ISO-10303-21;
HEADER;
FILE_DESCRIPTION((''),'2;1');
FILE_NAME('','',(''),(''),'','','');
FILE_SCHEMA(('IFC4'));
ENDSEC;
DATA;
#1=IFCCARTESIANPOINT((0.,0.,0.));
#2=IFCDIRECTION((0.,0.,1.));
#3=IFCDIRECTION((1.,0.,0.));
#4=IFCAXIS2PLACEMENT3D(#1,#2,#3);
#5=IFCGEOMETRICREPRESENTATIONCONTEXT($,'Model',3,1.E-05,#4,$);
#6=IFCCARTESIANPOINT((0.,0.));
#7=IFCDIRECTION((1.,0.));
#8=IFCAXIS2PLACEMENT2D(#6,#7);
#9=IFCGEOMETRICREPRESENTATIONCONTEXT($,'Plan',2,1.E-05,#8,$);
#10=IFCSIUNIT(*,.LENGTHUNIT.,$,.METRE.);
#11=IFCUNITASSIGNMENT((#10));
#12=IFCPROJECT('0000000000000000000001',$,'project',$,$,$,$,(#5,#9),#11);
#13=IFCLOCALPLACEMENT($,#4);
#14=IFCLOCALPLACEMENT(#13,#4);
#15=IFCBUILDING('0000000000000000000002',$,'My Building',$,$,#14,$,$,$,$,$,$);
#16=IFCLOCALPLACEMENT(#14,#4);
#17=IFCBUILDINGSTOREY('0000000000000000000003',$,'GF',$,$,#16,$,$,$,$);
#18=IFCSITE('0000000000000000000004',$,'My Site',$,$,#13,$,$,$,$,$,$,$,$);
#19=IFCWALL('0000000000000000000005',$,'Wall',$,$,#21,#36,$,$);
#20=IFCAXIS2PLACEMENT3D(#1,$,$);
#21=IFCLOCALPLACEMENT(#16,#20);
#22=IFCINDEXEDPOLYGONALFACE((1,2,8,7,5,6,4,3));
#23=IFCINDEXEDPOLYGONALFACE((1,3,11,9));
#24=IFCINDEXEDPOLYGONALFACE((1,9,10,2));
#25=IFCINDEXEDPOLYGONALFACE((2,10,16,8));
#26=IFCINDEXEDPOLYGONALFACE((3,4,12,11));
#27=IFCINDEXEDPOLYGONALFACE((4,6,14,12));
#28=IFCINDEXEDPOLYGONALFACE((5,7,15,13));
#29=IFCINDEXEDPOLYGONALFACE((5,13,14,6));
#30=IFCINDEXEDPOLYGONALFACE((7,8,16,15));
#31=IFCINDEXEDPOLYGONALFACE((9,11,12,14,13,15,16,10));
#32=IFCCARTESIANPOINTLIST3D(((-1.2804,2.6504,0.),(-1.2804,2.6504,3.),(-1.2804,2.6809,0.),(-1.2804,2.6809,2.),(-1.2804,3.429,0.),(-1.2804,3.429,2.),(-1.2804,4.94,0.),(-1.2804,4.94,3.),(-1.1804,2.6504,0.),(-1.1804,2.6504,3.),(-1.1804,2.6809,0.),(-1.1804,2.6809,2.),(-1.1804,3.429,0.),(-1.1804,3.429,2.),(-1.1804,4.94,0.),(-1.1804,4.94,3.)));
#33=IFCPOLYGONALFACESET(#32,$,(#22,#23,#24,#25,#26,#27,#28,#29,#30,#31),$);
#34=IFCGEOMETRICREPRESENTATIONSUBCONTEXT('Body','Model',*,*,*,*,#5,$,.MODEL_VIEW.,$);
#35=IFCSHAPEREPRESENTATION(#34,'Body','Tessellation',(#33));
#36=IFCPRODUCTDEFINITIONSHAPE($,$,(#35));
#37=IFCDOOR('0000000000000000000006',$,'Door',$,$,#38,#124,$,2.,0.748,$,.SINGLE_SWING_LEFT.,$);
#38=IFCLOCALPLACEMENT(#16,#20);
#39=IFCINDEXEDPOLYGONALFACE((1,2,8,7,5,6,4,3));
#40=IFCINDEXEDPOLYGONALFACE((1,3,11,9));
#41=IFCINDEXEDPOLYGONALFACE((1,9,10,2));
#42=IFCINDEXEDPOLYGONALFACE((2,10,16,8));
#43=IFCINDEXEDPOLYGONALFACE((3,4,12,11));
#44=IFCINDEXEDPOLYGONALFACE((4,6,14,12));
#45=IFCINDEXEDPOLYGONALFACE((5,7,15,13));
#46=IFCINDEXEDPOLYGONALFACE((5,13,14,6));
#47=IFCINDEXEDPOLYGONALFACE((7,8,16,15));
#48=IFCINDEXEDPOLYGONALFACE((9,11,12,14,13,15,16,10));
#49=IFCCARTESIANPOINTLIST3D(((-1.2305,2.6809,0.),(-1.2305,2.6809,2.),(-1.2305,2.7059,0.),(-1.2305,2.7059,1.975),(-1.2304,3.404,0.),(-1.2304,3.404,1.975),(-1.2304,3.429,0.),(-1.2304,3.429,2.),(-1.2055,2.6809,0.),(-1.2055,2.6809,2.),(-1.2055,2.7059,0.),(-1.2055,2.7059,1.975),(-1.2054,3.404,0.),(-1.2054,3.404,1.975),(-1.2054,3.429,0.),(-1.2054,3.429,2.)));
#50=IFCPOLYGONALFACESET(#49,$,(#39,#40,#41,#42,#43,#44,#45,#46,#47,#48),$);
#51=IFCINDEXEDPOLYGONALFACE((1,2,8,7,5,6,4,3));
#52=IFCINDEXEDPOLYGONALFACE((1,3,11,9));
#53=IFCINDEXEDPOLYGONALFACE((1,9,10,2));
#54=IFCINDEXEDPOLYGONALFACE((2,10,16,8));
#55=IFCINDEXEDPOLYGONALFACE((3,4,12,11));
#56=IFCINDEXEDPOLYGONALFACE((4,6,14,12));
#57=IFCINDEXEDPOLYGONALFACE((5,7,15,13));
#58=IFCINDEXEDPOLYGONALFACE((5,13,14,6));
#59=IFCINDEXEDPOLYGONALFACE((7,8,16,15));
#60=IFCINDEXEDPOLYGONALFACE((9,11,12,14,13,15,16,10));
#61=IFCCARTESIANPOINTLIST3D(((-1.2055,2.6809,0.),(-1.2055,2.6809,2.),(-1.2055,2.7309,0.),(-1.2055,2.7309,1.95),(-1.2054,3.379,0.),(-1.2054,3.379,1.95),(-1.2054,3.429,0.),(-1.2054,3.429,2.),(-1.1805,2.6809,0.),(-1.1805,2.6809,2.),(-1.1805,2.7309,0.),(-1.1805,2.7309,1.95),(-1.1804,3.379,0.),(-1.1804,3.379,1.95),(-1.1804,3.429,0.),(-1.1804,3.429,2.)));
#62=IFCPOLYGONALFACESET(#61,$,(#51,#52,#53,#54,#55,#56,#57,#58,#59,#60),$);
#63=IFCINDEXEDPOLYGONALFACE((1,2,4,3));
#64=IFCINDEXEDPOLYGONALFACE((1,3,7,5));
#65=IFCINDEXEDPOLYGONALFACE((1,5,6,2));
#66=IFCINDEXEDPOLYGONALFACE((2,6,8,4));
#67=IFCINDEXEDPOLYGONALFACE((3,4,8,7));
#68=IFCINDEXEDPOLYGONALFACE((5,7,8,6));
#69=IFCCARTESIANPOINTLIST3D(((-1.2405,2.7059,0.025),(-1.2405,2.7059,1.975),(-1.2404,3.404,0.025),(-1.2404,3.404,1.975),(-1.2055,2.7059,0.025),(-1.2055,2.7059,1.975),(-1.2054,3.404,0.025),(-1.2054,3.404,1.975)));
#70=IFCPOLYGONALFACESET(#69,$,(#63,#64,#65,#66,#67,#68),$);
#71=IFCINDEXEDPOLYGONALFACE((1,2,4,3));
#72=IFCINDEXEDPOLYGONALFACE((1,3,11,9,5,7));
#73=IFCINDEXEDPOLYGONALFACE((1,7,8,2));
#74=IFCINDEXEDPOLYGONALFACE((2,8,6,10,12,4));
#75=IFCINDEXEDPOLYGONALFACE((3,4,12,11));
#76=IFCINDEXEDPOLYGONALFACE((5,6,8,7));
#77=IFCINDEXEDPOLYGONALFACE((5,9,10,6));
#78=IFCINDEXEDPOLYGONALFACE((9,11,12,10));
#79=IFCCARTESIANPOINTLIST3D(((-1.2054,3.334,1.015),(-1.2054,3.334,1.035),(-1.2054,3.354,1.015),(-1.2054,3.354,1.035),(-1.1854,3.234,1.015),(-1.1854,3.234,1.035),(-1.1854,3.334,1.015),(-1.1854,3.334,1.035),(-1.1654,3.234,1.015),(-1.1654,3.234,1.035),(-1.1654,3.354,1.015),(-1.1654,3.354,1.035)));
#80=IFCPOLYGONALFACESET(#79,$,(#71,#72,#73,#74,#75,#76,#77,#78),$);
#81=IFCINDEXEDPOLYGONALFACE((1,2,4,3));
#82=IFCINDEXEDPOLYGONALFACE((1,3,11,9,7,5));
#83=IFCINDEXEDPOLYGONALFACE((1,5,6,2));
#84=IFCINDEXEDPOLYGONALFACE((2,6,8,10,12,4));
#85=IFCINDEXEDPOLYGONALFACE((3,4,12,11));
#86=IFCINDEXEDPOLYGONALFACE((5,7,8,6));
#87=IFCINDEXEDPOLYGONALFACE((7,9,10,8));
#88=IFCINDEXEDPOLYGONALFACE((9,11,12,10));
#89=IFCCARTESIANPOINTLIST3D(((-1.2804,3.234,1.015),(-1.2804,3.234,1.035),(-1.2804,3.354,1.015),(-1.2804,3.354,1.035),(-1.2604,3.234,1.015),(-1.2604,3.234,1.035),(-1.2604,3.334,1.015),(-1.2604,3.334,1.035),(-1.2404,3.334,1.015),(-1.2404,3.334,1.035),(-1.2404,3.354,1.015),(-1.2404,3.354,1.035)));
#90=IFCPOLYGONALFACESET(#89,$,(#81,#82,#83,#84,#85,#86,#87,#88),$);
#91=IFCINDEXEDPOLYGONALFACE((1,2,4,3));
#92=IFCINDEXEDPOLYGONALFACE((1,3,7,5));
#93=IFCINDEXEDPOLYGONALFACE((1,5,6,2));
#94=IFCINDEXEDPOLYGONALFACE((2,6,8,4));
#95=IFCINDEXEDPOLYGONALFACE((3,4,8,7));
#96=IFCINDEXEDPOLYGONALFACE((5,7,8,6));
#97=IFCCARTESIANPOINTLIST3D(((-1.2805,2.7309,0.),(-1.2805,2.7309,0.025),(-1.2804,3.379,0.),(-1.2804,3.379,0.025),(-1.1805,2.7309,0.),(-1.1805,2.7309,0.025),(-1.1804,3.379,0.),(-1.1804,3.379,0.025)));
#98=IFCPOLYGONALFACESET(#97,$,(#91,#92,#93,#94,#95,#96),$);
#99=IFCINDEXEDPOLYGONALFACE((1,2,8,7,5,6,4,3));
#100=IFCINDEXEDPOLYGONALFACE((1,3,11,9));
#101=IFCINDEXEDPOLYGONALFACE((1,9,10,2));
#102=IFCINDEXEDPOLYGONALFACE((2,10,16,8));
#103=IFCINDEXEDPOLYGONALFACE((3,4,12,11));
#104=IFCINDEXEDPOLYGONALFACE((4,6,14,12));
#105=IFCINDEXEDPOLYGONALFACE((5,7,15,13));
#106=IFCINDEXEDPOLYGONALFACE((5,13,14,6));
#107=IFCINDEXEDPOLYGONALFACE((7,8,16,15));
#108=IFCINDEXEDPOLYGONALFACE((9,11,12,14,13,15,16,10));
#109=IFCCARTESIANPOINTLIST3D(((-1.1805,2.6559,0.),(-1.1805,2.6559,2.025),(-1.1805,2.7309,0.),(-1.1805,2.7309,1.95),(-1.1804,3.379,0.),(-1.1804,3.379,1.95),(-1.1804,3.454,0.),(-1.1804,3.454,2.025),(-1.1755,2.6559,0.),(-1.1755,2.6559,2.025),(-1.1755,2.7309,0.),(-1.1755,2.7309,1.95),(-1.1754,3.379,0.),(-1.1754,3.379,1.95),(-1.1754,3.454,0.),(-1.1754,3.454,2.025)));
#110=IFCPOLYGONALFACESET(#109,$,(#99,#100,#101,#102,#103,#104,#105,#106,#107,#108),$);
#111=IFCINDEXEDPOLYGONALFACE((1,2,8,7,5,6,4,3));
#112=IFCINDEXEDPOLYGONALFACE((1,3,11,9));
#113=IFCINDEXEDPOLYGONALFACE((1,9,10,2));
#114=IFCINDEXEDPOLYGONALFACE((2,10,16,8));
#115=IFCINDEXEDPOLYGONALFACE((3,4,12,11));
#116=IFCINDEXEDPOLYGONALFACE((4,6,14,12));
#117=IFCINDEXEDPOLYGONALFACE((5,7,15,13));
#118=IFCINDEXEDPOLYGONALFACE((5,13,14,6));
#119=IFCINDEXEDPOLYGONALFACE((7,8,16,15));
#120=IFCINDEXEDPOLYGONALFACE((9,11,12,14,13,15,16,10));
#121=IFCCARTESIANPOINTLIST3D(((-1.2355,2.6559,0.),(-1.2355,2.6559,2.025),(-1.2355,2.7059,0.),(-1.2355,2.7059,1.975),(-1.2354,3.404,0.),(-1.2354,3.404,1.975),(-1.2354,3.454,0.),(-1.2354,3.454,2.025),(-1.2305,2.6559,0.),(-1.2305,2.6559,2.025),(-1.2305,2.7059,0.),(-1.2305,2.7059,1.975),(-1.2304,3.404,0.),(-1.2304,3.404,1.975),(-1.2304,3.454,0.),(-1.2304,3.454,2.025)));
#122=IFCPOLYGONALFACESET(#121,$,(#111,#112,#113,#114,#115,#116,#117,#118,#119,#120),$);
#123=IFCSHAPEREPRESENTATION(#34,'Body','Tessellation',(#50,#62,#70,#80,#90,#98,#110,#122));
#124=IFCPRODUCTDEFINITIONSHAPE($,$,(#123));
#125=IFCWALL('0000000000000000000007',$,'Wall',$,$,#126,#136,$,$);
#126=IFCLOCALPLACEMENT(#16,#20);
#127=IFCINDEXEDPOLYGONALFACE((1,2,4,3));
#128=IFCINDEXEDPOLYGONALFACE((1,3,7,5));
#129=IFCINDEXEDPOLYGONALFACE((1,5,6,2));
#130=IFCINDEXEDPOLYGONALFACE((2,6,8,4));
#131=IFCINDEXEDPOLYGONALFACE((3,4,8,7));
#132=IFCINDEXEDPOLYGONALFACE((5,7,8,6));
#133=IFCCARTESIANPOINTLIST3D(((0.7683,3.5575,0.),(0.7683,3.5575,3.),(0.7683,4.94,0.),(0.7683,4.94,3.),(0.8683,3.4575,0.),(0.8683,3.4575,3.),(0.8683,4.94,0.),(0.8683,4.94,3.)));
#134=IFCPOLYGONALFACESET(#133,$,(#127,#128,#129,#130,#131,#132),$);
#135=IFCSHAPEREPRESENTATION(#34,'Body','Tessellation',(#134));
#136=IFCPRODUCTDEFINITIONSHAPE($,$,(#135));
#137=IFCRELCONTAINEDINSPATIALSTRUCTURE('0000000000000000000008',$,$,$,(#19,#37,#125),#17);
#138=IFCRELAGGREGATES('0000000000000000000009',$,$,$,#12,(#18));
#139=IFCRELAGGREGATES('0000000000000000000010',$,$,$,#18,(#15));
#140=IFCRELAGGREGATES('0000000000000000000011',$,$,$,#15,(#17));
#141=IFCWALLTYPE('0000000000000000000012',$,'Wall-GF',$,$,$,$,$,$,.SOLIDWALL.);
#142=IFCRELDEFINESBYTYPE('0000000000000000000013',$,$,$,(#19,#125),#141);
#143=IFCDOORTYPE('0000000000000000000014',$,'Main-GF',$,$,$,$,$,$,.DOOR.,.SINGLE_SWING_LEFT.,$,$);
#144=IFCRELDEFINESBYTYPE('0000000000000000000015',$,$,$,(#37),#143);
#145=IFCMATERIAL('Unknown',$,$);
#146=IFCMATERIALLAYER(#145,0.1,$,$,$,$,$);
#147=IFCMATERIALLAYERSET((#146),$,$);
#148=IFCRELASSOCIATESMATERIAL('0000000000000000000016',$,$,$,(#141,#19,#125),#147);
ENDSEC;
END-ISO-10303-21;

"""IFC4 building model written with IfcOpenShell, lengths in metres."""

from ifc_helpers import new_model, entity, si_unit, frame, origin_with_axes, origin_2d_with_axis, place, context, subcontext, project, spatial, line, indexed_curve, outline, extrude, shape, source, transform, mapped, material, layer, layer_set, layer_usage, type_object, type_shapes, element, fill, save


model = new_model("IFC4")

# Units and contexts
model_context = context("Model", 3, precision=1e-05, world=origin_with_axes())
plan_context = context("Plan", 2, precision=1e-05, world=origin_2d_with_axis())
body_context_1 = subcontext(model_context, "Body", "Model", "MODEL_VIEW")
body_context_2 = subcontext(plan_context, "Body", "Plan", "PLAN_VIEW")
ifc_project = project(units=[si_unit("LENGTHUNIT", "METRE")], contexts=[model_context, plan_context])

# Site, building, storey
site_placement = place(None, origin_with_axes())
site = spatial("IfcSite", under=ifc_project, at=site_placement, Name="My Site")
building_placement = place(site_placement, origin_with_axes())
building = spatial("IfcBuilding", under=site, at=building_placement, Name="My Building")
storey_placement = place(building_placement, origin_with_axes())
storey = spatial("IfcBuildingStorey", under=building, at=storey_placement, Name="GF")

# Shared definitions
ifc_material = material(Name="Unknown")

# Shared definitions
ifc_layer_1 = layer(ifc_material, 0.1)
ifc_layer_set_1 = layer_set([ifc_layer_1])
wall_type = type_object("IfcWallType", Name="Wall-GF", PredefinedType="SOLIDWALL", material=ifc_layer_set_1)
shared_shape_1 = source(origin_with_axes(), body_context_1, "Body", "SweptSolid", [
    extrude(outline(indexed_curve([(0.0, 0.0), (0.748, 0.0), (0.748, 2.0), (0.0, 2.0)], segments=[line(1, 2, 3, 4, 1)])), frame((0.0, -0.6, 0.0), z_axis=(0.0, -1.0, 0.0), x_axis=(1.0, 0.0, 0.0)), (0.0, 0.0, -1.0), 1.2),
])
door_type_1 = type_object("IfcDoorType", Name="Main-GF", OperationType="SINGLE_SWING_LEFT", PredefinedType="DOOR")
shared_shape_2 = source(origin_with_axes(), body_context_1, "Body", "SweptSolid", [
    extrude(outline(indexed_curve([(0.0, 0.0), (0.0, 2.0), (0.748, 2.0), (0.748, 0.0), (0.723, 0.0), (0.723, 1.975), (0.025, 1.975), (0.025, 0.0)], segments=[line(1, 2, 3, 4, 5, 6, 7, 8, 1)])), frame((0.0, 0.025, 0.0), z_axis=(0.0, -1.0, 0.0), x_axis=(1.0, 0.0, 0.0)), (0.0, 0.0, -1.0), 0.025),
    extrude(outline(indexed_curve([(0.0, 0.0), (0.0, 2.0), (0.748, 2.0), (0.748, 0.0), (0.698, 0.0), (0.698, 1.95), (0.05, 1.95), (0.05, 0.0)], segments=[line(1, 2, 3, 4, 5, 6, 7, 8, 1)])), frame((0.0, 0.0, 0.0), z_axis=(0.0, -1.0, 0.0), x_axis=(1.0, 0.0, 0.0)), (0.0, 0.0, -1.0), 0.025),
    extrude(outline(indexed_curve([(0.0, 0.0), (0.698, 0.0), (0.698, 0.035), (0.0, 0.035)], segments=[line(1, 2, 3, 4, 1)])), frame((0.025, 0.025, 0.025), z_axis=(0.0, 0.0, 1.0), x_axis=(1.0, 0.0, 0.0)), (0.0, 0.0, 1.0), 1.95),
    extrude(outline(indexed_curve([(0.0, 0.0), (0.0, -0.04), (-0.12, -0.04), (-0.12, -0.02), (-0.02, -0.02), (-0.02, 0.0)], segments=[line(1, 2, 3, 4, 5, 6, 1)])), frame((0.673, 0.025, 1.015), z_axis=(0.0, 0.0, 1.0), x_axis=(1.0, 0.0, 0.0)), (0.0, 0.0, 1.0), 0.02),
    extrude(outline(indexed_curve([(0.0, 0.0), (0.0, 0.04), (-0.12, 0.04), (-0.12, 0.02), (-0.02, 0.02), (-0.02, 0.0)], segments=[line(1, 2, 3, 4, 5, 6, 1)])), frame((0.673, 0.06, 1.015), z_axis=(0.0, 0.0, 1.0), x_axis=(1.0, 0.0, 0.0)), (0.0, 0.0, 1.0), 0.02),
    extrude(outline(indexed_curve([(0.0, 0.0), (0.648, 0.0), (0.648, 0.1), (0.0, 0.1)], segments=[line(1, 2, 3, 4, 1)])), frame((0.05, 0.0, 0.0), z_axis=(0.0, 0.0, 1.0), x_axis=(1.0, 0.0, 0.0)), (0.0, 0.0, 1.0), 0.025),
    extrude(outline(indexed_curve([(0.0, 0.0), (0.0, 2.025), (0.798, 2.025), (0.798, 0.0), (0.723, 0.0), (0.723, 1.95), (0.075, 1.95), (0.075, 0.0)], segments=[line(1, 2, 3, 4, 5, 6, 7, 8, 1)])), frame((-0.025, -0.005, 0.0), z_axis=(0.0, -1.0, 0.0), x_axis=(1.0, 0.0, 0.0)), (0.0, 0.0, -1.0), 0.005),
    extrude(outline(indexed_curve([(0.0, 0.0), (0.0, 2.025), (0.798, 2.025), (0.798, 0.0), (0.748, 0.0), (0.748, 1.975), (0.05, 1.975), (0.05, 0.0)], segments=[line(1, 2, 3, 4, 5, 6, 7, 8, 1)])), frame((-0.025, 0.05, 0.0), z_axis=(0.0, -1.0, 0.0), x_axis=(1.0, 0.0, 0.0)), (0.0, 0.0, -1.0), 0.005),
])
shared_shape_3 = source(origin_with_axes(), body_context_2, "Body", "Curve2D", [
    entity("IfcIndexedPolyCurve", entity("IfcCartesianPointList2D", [[0.0, 0.0], [0.0, 0.05], [0.025, 0.05], [0.025, 0.025], [0.05, 0.025], [0.05, 0.0]]), [entity("IfcLineIndex", [1, 2, 3, 4, 5, 6, 1])]),
    entity("IfcIndexedPolyCurve", entity("IfcCartesianPointList2D", [[0.748, 0.0], [0.748, 0.05], [0.723, 0.05], [0.723, 0.025], [0.698, 0.025], [0.698, 0.0]]), [entity("IfcLineIndex", [1, 2, 3, 4, 5, 6, 1])]),
    entity("IfcTrimmedCurve", entity("IfcEllipse", entity("IfcAxis2Placement2D", entity("IfcCartesianPoint", [0.06, 0.05]), entity("IfcDirection", [1.0, 0.0])), 0.663, 0.698), [entity("IfcCartesianPoint", [0.723, 0.05])], [entity("IfcCartesianPoint", [0.06, 0.748])], True, "CARTESIAN"),
    entity("IfcIndexedPolyCurve", entity("IfcCartesianPointList2D", [[0.025, 0.05], [0.06, 0.05], [0.06, 0.748], [0.025, 0.748]]), [entity("IfcLineIndex", [1, 2, 3, 4, 1])]),
])
type_shapes(door_type_1, [shared_shape_2, shared_shape_3])

# Wall, opening, door
ifc_layer_usage_1 = layer_usage(ifc_layer_set_1, "AXIS2", "POSITIVE", 0.0)
wall_1_placement = place(storey_placement, frame((-1.1804, 2.6504, 0.0), z_axis=(0.0, 0.0, 1.0), x_axis=(0.0, 1.0, 0.0)))
wall_1 = element("IfcWall", 1, at=wall_1_placement, inside=storey, type_object=wall_type, material=ifc_layer_usage_1, Name="Wall", context=body_context_1, shape_type="SweptSolid", body=[
    extrude(outline(indexed_curve([(0.0, 0.0), (0.0, 0.1), (2.2896, 0.1), (2.2896, 0.0)], segments=[line(1, 2, 3, 4, 1)])), origin_with_axes(), (0.0, 0.0, 1.0), 3.0),
])
opening_1_placement = place(wall_1_placement, frame((0.0306, 0.0, 0.0), z_axis=(0.0, 0.0, 1.0), x_axis=(1.0, 0.0, 0.0)))
opening_1 = element("IfcOpeningElement", 2, at=opening_1_placement, cuts=wall_1, PredefinedType="OPENING", context=body_context_1, shape_type="MappedRepresentation", body=[
    mapped(shared_shape_1, transform((0.0, 0.0, 0.0), x_axis=(1.0, 0.0, 0.0), y_axis=(0.0, 1.0, 0.0), z_axis=(0.0, 0.0, 1.0), scale=1.0)),
])
door_1_placement = place(opening_1_placement, frame((0.0, 0.0, 0.0), z_axis=(0.0, 0.0, 1.0), x_axis=(1.0, 0.0, 0.0)))
door_1 = element("IfcDoor", 3, at=door_1_placement, inside=storey, type_object=door_type_1, Name="Door", OperationType="SINGLE_SWING_LEFT", OverallHeight=2.0, OverallWidth=0.748, shapes=[
    shape(body_context_1, "Body", "MappedRepresentation", [mapped(shared_shape_2, transform((0.0, 0.0, 0.0), x_axis=(1.0, 0.0, 0.0), y_axis=(0.0, 1.0, 0.0), z_axis=(0.0, 0.0, 1.0), scale=1.0))]),
    shape(body_context_2, "Body", "MappedRepresentation", [mapped(shared_shape_3, transform((0.0, 0.0, 0.0), x_axis=(1.0, 0.0, 0.0), y_axis=(0.0, 1.0, 0.0), z_axis=(0.0, 0.0, 1.0), scale=1.0))]),
])
fill(opening_1, door_1)

# Wall
ifc_layer_usage_2 = layer_usage(ifc_layer_set_1, "AXIS2", "POSITIVE", 0.0)
wall_2_placement = place(storey_placement, frame((0.7683, 5.04, 0.0), z_axis=(0.0, 0.0, 1.0), x_axis=(0.0, -1.0, 0.0)))
element("IfcWall", 4, at=wall_2_placement, inside=storey, type_object=wall_type, material=ifc_layer_usage_2, Name="Wall", context=body_context_1, shape_type="SweptSolid", body=[
    extrude(outline(indexed_curve([(0.1, 0.0), (0.1, 0.1), (1.5825, 0.1), (1.4825, 0.0)], segments=[line(1, 2, 3, 4, 1)])), origin_with_axes(), (0.0, 0.0, 1.0), 3.0),
])

save(model, "model.ifc")
